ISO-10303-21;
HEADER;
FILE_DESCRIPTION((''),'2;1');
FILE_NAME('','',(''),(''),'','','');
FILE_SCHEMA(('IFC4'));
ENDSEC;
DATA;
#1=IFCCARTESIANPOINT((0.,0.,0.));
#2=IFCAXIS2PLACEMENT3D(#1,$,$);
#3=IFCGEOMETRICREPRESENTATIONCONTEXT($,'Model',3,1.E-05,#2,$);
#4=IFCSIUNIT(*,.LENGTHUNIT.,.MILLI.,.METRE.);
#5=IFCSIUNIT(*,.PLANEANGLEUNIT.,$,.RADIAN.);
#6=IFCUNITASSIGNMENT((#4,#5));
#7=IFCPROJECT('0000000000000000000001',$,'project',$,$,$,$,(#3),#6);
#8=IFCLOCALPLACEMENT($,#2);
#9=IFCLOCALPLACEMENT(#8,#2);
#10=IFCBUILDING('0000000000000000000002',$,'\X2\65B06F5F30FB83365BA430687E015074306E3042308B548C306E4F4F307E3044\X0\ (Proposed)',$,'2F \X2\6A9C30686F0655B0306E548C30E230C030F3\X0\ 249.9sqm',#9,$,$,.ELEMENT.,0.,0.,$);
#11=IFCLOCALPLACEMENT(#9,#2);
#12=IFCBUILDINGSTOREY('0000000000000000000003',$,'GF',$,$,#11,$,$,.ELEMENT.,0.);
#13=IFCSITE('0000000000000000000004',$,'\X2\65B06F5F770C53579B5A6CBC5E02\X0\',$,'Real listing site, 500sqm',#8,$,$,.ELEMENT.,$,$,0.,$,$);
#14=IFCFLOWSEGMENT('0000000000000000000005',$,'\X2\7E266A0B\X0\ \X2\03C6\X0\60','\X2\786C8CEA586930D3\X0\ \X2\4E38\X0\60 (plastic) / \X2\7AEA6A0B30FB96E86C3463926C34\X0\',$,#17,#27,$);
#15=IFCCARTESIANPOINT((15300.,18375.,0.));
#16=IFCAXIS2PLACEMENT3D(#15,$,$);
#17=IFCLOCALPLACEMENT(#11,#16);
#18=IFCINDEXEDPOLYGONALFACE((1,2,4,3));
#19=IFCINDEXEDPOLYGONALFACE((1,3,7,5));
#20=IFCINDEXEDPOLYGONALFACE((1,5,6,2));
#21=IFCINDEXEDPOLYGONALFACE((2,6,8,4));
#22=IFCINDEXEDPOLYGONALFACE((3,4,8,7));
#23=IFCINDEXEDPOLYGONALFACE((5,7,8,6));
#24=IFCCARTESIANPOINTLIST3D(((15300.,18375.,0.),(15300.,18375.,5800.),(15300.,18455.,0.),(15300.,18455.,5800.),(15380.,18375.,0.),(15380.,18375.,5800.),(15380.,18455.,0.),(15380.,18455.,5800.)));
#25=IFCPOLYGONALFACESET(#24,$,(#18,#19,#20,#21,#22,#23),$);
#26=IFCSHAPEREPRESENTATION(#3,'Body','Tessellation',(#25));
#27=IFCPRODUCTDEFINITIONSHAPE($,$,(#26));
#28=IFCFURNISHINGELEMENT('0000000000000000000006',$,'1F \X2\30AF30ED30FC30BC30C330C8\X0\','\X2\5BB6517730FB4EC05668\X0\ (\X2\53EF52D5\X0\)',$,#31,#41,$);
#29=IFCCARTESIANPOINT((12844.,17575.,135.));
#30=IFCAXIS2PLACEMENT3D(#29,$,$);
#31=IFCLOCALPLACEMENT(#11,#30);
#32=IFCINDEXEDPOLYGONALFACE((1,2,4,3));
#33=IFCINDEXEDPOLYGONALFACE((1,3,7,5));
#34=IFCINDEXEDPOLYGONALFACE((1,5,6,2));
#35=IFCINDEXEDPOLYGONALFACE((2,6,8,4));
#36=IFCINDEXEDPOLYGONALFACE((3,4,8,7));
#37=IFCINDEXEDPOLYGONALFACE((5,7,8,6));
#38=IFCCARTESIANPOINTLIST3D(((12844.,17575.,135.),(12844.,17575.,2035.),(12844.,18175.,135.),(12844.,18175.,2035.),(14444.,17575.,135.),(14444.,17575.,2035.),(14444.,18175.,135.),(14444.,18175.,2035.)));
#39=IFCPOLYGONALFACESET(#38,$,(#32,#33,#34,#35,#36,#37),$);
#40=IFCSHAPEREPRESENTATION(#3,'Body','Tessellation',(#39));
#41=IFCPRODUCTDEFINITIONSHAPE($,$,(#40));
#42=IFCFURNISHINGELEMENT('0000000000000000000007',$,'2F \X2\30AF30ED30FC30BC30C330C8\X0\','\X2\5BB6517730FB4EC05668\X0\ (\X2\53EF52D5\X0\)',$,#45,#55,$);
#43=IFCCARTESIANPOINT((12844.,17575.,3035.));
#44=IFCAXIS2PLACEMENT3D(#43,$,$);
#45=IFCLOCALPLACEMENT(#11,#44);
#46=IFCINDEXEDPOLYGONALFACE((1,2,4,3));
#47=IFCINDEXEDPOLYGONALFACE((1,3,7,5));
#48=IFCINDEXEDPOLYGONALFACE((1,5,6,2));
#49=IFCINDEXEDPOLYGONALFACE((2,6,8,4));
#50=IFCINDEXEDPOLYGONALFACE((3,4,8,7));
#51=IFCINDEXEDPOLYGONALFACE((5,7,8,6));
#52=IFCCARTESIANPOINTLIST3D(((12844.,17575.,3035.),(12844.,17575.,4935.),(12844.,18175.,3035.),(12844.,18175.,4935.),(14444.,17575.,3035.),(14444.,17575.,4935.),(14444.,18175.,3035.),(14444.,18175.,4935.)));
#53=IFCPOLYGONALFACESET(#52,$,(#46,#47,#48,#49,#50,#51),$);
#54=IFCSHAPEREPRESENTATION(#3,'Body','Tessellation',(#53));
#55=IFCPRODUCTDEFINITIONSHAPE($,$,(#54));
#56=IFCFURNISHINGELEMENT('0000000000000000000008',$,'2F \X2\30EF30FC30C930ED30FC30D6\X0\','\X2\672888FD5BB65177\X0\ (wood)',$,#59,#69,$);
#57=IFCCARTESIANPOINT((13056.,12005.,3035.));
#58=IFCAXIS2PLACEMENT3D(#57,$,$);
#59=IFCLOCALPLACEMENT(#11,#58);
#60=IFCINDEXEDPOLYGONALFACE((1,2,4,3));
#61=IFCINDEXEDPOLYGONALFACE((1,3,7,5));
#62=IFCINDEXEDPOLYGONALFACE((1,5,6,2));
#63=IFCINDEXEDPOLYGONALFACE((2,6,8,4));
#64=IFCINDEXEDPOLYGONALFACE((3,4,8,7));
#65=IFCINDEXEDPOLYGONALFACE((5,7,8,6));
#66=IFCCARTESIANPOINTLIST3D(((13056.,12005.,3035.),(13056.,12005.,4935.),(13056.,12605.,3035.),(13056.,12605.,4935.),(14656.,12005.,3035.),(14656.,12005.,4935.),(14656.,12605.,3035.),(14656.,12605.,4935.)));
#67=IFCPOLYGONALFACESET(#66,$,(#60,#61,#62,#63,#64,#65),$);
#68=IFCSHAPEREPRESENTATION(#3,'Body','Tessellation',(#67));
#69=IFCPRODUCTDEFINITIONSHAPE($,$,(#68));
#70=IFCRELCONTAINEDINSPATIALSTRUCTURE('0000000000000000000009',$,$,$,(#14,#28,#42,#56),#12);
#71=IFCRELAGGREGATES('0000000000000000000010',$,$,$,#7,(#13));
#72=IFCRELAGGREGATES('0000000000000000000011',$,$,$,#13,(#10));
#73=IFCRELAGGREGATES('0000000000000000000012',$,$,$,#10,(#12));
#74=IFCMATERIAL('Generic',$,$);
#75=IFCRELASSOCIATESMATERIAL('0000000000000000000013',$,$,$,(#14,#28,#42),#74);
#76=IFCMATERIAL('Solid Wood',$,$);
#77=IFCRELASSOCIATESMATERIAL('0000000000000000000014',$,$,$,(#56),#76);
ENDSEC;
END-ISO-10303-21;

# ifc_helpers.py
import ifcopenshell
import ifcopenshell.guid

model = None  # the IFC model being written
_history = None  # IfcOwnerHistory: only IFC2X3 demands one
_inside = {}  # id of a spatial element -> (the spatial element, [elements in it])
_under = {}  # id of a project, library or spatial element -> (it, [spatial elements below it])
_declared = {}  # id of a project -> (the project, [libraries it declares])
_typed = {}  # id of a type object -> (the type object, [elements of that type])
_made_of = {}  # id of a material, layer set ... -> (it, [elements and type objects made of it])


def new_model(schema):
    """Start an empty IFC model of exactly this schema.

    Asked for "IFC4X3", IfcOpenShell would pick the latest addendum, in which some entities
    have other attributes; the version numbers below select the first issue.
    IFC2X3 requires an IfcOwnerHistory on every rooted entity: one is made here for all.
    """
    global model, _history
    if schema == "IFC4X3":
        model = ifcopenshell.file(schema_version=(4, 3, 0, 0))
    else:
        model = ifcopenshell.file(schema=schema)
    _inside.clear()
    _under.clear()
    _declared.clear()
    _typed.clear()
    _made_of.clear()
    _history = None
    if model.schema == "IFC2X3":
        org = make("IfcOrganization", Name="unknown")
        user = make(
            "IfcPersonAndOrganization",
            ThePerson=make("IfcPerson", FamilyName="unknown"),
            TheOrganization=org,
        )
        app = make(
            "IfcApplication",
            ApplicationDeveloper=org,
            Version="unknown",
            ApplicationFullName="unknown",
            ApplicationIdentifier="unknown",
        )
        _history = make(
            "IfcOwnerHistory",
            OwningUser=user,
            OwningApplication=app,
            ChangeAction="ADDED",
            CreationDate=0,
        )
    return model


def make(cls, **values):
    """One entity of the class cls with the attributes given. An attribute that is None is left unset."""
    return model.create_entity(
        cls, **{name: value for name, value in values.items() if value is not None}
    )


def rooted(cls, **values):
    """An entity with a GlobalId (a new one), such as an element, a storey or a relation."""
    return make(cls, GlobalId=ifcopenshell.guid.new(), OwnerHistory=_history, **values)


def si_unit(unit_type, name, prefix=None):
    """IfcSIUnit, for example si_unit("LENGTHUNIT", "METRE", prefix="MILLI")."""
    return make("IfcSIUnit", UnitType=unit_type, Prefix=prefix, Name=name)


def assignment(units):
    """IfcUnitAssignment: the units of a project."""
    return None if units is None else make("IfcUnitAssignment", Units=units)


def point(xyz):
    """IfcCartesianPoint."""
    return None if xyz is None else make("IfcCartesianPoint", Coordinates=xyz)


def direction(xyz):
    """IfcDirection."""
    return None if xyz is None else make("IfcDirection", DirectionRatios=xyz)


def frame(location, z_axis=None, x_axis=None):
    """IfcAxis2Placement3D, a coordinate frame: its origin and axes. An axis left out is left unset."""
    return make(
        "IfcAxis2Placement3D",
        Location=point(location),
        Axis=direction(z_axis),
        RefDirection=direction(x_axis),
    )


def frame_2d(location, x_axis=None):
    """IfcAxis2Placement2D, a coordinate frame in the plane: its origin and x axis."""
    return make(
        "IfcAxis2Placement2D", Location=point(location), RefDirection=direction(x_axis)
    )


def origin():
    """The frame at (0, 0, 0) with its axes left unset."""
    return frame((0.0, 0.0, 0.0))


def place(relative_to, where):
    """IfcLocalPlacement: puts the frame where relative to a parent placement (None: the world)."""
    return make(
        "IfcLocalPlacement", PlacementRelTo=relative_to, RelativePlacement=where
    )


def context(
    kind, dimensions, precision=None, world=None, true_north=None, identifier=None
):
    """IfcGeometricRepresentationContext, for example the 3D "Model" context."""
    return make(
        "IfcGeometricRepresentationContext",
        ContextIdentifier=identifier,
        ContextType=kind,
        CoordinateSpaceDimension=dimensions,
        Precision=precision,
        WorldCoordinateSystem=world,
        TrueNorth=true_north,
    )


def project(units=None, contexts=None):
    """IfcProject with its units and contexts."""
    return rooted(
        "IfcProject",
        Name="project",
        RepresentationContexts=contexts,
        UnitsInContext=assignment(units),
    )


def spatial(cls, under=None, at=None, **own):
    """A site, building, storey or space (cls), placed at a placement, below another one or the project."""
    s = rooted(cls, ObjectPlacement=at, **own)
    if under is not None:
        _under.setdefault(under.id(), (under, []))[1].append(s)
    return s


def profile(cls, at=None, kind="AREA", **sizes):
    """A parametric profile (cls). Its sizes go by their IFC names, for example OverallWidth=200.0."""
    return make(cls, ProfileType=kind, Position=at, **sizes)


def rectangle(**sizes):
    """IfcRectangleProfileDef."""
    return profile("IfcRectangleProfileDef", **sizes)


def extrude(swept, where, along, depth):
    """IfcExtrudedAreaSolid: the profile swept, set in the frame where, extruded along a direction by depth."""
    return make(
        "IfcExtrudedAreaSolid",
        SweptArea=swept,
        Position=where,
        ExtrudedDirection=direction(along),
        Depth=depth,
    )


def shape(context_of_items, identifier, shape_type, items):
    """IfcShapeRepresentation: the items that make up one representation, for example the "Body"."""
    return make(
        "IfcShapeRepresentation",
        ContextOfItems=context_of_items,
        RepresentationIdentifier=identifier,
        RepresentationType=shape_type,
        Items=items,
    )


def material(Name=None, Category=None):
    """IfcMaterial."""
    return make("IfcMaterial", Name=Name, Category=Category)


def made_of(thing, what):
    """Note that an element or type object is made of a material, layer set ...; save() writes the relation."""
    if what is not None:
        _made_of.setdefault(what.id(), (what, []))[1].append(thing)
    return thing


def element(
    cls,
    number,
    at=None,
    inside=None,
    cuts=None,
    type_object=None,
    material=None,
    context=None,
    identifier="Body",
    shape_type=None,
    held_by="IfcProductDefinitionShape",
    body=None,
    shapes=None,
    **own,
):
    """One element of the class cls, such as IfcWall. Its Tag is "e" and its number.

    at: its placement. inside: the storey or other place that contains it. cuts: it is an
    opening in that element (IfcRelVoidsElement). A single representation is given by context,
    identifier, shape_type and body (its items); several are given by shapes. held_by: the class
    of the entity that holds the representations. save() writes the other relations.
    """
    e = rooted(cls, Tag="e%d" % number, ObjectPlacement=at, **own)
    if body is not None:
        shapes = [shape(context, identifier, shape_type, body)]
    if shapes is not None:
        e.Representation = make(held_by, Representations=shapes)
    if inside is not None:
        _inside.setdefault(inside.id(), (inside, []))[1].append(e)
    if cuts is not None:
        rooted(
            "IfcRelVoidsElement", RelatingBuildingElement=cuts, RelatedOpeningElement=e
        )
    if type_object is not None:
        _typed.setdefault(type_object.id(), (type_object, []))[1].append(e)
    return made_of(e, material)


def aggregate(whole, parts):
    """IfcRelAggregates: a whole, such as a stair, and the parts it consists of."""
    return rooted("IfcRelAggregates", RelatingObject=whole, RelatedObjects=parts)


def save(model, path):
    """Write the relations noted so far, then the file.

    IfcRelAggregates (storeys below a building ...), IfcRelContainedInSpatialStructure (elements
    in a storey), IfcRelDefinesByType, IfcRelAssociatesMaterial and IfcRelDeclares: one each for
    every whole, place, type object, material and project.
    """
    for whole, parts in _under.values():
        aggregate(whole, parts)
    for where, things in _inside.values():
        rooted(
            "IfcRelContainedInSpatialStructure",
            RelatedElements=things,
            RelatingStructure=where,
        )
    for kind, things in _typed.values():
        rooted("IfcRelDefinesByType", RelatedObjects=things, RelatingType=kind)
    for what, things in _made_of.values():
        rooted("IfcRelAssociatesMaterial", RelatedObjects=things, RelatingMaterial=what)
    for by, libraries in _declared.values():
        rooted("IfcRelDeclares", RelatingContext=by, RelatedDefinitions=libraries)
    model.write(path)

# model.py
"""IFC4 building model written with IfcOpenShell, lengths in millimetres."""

from ifc_helpers import new_model, si_unit, frame, frame_2d, origin, place, context, project, spatial, rectangle, extrude, material, element, save


model = new_model("IFC4")

# Units and contexts
model_context = context("Model", 3, precision=1e-05, world=origin())
ifc_project = project(units=[si_unit("LENGTHUNIT", "METRE", prefix="MILLI"), si_unit("PLANEANGLEUNIT", "RADIAN")], contexts=[model_context])

# Site, building, storey
site_placement = place(None, origin())
site = spatial("IfcSite", under=ifc_project, at=site_placement, Name="新潟県南魚沼市", ObjectType="Real listing site, 500sqm", CompositionType="ELEMENT", RefElevation=0.0)
building_placement = place(site_placement, origin())
building = spatial("IfcBuilding", under=site, at=building_placement, Name="新潟・茶室と縁側のある和の住まい (Proposed)", ObjectType="2F 檜と漆喰の和モダン 249.9sqm", CompositionType="ELEMENT", ElevationOfRefHeight=0.0, ElevationOfTerrain=0.0)
storey_placement = place(building_placement, origin())
storey = spatial("IfcBuildingStorey", under=building, at=storey_placement, Name="GF", CompositionType="ELEMENT", Elevation=0.0)

# Shared definitions
ifc_material_1 = material(Name="Solid Wood")

# Shared definitions
ifc_material_2 = material(Name="Generic")

# Flow segment
flow_segment_placement = place(storey_placement, frame((15300.0, 18375.0, 0.0)))
element("IfcFlowSegment", 1, at=flow_segment_placement, inside=storey, material=ifc_material_2, Name="縦樋 φ60", Description="硬質塩ビ 丸60 (plastic) / 竪樋・雨水排水", context=model_context, shape_type="SweptSolid", body=[
    extrude(rectangle(XDim=80.0, YDim=80.0, at=frame_2d((40.0, 40.0))), frame((15300.0, 18375.0, 0.0)), (0.0, 0.0, 1.0), 5800.0),
])

# Furnishing elements
furnishing_1_placement = place(storey_placement, frame((12844.0, 17575.0, 135.0)))
element("IfcFurnishingElement", 2, at=furnishing_1_placement, inside=storey, material=ifc_material_2, Name="1F クローゼット", Description="家具・什器 (可動)", context=model_context, shape_type="SweptSolid", body=[
    extrude(rectangle(XDim=1600.0, YDim=600.0, at=frame_2d((800.0, 300.0))), frame((12844.0, 17575.0, 135.0)), (0.0, 0.0, 1.0), 1900.0),
])
furnishing_2_placement = place(storey_placement, frame((12844.0, 17575.0, 3035.0)))
element("IfcFurnishingElement", 3, at=furnishing_2_placement, inside=storey, material=ifc_material_2, Name="2F クローゼット", Description="家具・什器 (可動)", context=model_context, shape_type="SweptSolid", body=[
    extrude(rectangle(XDim=1600.0, YDim=600.0, at=frame_2d((800.0, 300.0))), frame((12844.0, 17575.0, 3035.0)), (0.0, 0.0, 1.0), 1900.0),
])
furnishing_3_placement = place(storey_placement, frame((13056.0, 12005.0, 3035.0)))
element("IfcFurnishingElement", 4, at=furnishing_3_placement, inside=storey, material=ifc_material_1, Name="2F ワードローブ", Description="木製家具 (wood)", context=model_context, shape_type="SweptSolid", body=[
    extrude(rectangle(XDim=1600.0, YDim=600.0, at=frame_2d((800.0, 300.0))), frame((13056.0, 12005.0, 3035.0)), (0.0, 0.0, 1.0), 1900.0),
])

save(model, "model.ifc")
